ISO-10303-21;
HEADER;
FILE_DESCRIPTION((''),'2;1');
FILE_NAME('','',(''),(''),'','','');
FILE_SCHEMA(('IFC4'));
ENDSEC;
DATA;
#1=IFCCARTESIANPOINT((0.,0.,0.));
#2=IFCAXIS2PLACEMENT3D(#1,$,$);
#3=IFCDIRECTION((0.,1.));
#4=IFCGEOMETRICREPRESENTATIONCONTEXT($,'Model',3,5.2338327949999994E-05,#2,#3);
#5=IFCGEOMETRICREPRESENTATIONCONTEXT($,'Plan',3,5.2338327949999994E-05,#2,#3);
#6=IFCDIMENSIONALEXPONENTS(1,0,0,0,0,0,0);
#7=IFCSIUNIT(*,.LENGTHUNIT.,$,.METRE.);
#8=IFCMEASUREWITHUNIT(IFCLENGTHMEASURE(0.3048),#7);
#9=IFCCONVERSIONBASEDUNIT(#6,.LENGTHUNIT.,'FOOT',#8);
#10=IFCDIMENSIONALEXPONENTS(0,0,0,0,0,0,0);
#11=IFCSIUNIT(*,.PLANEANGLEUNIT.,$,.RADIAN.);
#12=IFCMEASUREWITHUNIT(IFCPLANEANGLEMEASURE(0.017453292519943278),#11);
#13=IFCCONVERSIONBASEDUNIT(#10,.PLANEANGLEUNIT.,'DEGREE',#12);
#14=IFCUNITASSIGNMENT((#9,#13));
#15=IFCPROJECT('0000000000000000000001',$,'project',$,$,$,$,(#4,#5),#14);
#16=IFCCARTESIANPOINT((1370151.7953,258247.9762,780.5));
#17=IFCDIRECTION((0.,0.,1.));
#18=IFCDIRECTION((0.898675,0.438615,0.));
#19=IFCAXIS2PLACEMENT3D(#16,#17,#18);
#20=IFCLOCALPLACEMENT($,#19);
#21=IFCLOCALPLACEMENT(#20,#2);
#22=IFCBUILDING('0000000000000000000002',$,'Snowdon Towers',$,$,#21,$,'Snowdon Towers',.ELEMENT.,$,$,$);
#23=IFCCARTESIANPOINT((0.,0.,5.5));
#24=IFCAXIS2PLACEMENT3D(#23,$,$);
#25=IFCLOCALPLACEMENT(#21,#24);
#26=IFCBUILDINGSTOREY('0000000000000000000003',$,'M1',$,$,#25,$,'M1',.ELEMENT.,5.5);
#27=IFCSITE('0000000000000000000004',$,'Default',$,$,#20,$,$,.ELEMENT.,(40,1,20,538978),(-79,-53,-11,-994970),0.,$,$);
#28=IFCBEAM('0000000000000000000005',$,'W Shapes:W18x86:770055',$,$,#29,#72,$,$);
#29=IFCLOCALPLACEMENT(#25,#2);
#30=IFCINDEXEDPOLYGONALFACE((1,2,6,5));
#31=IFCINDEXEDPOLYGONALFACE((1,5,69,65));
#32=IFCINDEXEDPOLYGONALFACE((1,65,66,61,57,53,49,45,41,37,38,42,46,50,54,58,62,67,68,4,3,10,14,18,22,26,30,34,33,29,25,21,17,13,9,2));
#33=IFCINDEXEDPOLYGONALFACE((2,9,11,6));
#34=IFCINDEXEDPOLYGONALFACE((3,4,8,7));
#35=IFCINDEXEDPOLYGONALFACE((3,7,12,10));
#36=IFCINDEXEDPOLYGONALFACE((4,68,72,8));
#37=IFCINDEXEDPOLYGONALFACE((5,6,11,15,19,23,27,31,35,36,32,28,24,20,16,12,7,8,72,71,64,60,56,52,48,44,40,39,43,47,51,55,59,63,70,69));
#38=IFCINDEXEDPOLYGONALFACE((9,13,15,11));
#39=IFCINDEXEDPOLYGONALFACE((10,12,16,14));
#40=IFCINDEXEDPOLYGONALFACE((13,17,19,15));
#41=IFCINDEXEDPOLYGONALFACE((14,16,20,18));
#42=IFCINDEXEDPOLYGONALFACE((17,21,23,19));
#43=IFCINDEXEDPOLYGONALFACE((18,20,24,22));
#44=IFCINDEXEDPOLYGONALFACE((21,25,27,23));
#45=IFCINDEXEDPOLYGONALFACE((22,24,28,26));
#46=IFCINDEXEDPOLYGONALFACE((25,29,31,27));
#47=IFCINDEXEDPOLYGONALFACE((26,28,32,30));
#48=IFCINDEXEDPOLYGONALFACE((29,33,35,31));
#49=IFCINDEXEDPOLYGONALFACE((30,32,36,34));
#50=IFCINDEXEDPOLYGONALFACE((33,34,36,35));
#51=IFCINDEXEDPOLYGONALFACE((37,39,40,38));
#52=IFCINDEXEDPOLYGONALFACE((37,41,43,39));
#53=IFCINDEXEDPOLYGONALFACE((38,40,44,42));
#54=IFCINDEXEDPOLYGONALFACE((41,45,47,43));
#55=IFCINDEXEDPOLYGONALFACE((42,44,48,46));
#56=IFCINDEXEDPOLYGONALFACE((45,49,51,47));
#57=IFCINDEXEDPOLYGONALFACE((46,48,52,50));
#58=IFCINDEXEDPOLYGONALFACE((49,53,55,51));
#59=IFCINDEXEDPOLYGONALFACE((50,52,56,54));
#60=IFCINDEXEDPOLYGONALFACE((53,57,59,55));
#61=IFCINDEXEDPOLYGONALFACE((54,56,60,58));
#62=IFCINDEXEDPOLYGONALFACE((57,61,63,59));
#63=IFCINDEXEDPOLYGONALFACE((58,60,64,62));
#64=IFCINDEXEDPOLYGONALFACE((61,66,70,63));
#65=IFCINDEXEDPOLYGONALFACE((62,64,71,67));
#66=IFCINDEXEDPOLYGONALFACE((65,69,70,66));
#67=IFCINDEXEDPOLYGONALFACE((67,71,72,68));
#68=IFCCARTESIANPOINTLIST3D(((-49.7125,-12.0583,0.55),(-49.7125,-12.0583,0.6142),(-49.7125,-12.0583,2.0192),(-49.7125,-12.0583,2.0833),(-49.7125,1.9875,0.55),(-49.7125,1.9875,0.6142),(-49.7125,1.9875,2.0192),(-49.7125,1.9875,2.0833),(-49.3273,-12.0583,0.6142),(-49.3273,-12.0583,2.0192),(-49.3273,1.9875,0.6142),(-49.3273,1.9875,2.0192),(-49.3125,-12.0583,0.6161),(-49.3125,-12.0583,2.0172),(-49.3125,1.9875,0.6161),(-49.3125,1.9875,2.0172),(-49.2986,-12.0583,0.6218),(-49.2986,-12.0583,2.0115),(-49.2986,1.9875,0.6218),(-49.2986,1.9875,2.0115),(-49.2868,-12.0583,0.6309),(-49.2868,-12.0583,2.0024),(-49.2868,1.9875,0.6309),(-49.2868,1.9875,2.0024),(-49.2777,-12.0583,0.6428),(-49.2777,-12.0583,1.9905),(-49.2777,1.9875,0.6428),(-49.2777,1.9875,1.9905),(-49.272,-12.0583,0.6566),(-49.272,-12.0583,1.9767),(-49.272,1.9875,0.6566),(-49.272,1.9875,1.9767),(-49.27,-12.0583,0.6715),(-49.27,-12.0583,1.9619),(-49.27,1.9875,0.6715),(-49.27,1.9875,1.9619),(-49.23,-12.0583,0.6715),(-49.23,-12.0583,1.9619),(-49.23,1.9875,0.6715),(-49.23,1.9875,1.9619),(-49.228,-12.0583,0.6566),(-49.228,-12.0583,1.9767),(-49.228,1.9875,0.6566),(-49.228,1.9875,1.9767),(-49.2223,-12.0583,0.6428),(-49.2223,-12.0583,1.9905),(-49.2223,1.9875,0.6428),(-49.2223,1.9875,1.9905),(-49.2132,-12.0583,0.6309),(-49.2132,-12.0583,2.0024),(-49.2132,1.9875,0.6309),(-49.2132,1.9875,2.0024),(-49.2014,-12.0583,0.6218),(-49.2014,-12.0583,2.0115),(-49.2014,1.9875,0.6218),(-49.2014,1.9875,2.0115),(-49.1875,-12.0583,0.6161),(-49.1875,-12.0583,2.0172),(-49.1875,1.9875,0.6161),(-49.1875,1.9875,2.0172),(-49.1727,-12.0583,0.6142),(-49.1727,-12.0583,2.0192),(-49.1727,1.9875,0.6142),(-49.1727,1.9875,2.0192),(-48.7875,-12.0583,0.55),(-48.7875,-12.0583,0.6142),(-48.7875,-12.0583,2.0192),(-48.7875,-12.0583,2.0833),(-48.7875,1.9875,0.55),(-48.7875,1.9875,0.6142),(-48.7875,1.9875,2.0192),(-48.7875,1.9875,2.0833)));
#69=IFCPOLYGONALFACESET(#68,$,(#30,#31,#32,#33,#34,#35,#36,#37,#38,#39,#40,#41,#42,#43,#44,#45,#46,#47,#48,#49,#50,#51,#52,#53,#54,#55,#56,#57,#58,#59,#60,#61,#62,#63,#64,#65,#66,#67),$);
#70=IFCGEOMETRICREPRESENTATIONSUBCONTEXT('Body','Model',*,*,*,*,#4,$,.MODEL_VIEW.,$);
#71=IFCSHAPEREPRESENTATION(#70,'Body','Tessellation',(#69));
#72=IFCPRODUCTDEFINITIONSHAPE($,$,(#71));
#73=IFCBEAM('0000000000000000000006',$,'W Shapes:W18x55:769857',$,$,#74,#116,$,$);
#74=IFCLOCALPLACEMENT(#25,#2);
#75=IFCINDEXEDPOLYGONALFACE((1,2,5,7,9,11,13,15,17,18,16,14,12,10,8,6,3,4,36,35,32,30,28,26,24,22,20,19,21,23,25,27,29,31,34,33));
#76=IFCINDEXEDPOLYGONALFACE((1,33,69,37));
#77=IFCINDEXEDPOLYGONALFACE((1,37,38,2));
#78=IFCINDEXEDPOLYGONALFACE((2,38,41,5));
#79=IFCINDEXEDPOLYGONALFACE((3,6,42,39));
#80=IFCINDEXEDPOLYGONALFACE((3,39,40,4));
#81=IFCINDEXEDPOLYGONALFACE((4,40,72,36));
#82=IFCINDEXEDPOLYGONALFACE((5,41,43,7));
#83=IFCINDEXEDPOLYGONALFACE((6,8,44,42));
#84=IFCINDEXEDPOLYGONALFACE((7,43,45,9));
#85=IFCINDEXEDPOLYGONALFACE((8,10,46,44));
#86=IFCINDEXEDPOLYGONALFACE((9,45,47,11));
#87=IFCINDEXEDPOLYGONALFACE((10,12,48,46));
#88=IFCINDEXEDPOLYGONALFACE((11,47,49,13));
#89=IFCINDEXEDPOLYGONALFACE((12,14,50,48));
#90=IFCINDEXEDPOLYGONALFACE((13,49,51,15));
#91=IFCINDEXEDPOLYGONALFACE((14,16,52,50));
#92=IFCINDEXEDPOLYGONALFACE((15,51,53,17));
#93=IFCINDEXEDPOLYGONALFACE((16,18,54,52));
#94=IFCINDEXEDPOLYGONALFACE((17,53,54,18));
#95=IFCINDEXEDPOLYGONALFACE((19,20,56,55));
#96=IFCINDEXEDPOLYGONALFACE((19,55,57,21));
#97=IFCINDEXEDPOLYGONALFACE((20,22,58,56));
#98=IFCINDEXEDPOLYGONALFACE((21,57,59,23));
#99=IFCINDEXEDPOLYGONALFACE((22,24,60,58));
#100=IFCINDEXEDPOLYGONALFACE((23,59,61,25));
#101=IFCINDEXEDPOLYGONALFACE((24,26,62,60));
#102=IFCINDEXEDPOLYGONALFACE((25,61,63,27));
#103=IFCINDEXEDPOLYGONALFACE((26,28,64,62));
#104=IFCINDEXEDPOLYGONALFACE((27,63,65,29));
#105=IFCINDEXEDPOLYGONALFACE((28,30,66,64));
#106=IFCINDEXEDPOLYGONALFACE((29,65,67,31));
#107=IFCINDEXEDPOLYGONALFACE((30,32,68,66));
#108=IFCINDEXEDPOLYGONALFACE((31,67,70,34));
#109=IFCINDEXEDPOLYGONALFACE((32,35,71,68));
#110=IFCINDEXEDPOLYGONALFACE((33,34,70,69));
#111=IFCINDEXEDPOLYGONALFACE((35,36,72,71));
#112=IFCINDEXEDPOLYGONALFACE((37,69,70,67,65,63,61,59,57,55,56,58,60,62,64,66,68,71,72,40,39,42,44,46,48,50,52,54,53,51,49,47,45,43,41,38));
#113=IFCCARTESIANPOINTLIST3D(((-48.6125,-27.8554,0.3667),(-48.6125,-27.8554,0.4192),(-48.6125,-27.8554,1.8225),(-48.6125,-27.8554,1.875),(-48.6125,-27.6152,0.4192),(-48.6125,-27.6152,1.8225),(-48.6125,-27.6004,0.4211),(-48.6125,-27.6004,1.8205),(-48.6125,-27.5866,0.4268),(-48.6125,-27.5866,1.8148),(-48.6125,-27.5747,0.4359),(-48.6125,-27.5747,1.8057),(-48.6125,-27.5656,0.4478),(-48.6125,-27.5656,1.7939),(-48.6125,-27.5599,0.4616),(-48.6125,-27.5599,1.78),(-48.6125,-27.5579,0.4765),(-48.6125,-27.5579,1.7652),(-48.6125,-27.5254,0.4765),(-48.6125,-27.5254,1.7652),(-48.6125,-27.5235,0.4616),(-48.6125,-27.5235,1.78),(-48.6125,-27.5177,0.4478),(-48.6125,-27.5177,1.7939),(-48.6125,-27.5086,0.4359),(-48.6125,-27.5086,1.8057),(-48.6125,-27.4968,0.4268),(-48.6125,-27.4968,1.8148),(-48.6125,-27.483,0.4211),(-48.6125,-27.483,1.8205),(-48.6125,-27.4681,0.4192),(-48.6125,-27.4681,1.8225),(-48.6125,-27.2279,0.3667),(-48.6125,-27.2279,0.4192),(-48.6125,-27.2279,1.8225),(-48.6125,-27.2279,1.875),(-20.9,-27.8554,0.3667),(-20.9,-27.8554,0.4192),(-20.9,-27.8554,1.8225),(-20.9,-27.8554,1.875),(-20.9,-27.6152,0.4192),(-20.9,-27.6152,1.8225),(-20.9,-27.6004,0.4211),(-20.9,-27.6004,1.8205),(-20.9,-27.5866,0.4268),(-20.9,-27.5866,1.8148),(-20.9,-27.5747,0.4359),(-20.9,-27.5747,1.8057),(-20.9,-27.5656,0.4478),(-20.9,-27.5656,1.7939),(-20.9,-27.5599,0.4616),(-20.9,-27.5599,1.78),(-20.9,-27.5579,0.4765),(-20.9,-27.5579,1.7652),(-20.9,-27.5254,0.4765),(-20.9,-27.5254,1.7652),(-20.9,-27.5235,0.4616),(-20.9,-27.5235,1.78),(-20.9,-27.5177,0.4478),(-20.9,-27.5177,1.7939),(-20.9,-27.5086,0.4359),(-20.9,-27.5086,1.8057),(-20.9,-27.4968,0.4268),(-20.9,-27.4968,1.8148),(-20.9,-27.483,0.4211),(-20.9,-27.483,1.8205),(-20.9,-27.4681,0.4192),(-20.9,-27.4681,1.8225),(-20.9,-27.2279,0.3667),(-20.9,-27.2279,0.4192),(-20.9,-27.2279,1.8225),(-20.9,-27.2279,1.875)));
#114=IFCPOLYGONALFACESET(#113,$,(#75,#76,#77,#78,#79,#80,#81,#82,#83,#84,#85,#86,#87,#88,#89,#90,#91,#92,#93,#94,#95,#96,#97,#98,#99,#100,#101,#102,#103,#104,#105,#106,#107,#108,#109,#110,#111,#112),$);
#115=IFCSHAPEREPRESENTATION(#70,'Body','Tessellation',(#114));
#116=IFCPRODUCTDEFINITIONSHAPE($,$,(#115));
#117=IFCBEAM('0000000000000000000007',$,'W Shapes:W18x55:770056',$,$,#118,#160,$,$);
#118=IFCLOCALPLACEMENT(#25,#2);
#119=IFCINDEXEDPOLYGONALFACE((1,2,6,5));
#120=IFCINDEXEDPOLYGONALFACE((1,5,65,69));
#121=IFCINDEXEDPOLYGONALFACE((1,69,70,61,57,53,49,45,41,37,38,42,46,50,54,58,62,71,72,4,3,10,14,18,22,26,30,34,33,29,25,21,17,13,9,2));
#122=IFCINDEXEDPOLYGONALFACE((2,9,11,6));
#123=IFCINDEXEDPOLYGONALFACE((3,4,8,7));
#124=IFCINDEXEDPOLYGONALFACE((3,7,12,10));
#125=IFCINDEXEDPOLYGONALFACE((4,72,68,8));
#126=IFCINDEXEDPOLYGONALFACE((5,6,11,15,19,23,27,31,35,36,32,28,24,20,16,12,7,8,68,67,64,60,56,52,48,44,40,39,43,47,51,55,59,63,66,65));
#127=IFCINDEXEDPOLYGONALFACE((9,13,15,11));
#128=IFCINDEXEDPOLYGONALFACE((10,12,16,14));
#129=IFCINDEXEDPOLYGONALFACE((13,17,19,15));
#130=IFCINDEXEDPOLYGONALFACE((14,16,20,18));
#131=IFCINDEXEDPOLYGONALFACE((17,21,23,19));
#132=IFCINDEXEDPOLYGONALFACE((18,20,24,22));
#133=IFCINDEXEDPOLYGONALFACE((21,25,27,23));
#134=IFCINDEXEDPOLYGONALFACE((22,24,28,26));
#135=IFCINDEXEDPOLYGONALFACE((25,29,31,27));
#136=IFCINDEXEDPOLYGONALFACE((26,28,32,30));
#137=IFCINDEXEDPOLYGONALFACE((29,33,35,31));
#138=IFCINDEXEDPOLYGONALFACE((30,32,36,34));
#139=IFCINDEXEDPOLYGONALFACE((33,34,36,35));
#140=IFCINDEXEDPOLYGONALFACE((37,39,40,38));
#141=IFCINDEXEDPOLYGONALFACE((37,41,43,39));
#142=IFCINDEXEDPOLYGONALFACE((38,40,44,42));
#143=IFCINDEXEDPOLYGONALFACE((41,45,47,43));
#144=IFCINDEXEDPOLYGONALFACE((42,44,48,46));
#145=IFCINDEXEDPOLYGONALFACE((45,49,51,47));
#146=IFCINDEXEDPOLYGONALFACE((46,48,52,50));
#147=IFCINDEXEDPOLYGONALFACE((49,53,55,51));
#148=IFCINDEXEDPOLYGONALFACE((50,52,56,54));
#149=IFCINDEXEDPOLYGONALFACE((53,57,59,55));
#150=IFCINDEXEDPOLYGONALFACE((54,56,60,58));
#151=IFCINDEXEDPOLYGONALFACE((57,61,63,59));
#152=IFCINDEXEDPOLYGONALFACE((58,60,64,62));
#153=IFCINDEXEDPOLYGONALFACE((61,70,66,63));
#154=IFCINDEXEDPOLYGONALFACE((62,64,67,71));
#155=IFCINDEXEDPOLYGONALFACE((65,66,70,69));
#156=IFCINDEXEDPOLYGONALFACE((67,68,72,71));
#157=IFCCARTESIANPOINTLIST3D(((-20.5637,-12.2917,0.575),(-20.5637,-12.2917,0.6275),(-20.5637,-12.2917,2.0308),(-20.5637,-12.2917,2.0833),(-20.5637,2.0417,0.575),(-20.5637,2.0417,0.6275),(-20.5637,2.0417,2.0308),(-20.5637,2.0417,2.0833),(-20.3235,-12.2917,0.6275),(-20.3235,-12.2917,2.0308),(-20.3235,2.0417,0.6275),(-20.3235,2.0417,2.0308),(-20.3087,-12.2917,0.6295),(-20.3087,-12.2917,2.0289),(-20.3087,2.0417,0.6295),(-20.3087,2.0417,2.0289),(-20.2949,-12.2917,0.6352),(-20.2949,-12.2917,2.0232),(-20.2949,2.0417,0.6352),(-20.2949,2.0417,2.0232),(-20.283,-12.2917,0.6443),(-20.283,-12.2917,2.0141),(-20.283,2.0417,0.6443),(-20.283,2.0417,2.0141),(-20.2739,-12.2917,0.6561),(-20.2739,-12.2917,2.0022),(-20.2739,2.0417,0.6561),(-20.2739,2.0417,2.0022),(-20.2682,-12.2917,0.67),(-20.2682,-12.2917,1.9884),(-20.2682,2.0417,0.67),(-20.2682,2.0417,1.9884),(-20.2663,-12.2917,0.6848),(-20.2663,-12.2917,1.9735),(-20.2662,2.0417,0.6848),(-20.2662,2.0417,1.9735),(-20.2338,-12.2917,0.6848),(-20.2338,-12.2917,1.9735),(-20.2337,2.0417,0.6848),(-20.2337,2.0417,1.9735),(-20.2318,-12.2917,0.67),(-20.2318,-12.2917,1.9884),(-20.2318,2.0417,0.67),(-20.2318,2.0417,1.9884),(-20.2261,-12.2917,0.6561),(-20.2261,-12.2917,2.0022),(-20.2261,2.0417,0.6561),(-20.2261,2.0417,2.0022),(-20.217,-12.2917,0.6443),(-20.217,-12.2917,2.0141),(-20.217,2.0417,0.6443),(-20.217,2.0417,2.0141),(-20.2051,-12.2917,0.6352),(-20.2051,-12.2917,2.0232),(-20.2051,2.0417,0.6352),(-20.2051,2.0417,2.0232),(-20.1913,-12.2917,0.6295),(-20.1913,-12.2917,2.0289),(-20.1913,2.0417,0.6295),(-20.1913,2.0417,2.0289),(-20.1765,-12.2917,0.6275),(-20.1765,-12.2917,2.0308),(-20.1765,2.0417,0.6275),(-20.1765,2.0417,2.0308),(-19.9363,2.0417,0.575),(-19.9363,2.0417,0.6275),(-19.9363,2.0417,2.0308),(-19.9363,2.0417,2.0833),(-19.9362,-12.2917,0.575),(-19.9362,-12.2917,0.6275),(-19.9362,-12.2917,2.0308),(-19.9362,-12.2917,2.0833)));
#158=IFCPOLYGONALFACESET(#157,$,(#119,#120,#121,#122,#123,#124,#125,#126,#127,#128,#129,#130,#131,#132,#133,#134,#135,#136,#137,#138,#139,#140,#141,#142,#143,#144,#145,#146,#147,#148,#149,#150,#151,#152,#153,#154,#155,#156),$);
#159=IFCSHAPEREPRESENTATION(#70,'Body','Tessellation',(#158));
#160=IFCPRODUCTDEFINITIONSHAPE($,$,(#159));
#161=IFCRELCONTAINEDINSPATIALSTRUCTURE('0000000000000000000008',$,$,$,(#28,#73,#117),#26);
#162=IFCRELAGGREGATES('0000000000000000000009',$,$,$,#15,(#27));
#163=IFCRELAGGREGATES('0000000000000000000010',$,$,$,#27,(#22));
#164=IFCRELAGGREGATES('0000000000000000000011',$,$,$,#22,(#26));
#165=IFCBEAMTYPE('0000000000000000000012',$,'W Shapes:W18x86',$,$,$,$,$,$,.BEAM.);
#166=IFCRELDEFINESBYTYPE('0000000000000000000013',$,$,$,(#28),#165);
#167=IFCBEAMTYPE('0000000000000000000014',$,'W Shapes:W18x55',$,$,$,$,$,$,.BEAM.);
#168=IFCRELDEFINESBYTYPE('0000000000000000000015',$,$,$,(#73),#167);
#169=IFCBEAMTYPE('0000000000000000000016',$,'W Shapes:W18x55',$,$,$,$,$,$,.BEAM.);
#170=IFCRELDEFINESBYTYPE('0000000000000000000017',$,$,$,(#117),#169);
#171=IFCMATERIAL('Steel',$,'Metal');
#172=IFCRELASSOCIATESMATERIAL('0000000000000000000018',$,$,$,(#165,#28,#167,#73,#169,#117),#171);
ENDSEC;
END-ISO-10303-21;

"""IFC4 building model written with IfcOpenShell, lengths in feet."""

from ifc_helpers import new_model, entity, si_unit, converted_unit, direction, frame, origin, place, context, subcontext, project, spatial, line, arc, indexed_curve, outline, extrude, source, transform, mapped, material, type_object, type_shapes, element, save


model = new_model("IFC4")

# Units and contexts
model_context = context("Model", 3, precision=5.2338327949999994e-05, world=origin(), true_north=direction((0.0, 1.0)))
plan_context = context("Plan", 3, precision=5.2338327949999994e-05, world=origin(), true_north=direction((0.0, 1.0)))
body_context = subcontext(model_context, "Body", "Model", "MODEL_VIEW")
ifc_project = project(units=[converted_unit("LENGTHUNIT", "FOOT", entity("IfcLengthMeasure", 0.3048), si_unit("LENGTHUNIT", "METRE"), dimensions=[1, 0, 0, 0, 0, 0, 0]), converted_unit("PLANEANGLEUNIT", "DEGREE", entity("IfcPlaneAngleMeasure", 0.017453292519943278), si_unit("PLANEANGLEUNIT", "RADIAN"), dimensions=[0, 0, 0, 0, 0, 0, 0])], contexts=[model_context, plan_context])

# Site, building, storey
site_placement = place(None, frame((1370151.7953, 258247.9762, 780.5), z_axis=(0.0, 0.0, 1.0), x_axis=(0.898675, 0.438615, 0.0)))
site = spatial("IfcSite", under=ifc_project, at=site_placement, Name="Default", CompositionType="ELEMENT", RefLatitude=(40, 1, 20, 538978), RefLongitude=(-79, -53, -11, -994970), RefElevation=0.0)
building_placement = place(site_placement, origin())
building = spatial("IfcBuilding", under=site, at=building_placement, Name="Snowdon Towers", LongName="Snowdon Towers", CompositionType="ELEMENT")
storey_placement = place(building_placement, frame((0.0, 0.0, 5.5)))
storey = spatial("IfcBuildingStorey", under=building, at=storey_placement, Name="M1", LongName="M1", CompositionType="ELEMENT", Elevation=5.5)

# Beams
ifc_material_1 = material(Name="Steel", Category="Metal")
beam_type_1 = type_object("IfcBeamType", Name="W Shapes:W18x86", PredefinedType="BEAM", material=ifc_material_1)
shared_shape_1 = source(origin(), body_context, "Body", "SweptSolid", [
    extrude(outline(indexed_curve([(-0.7667, -0.4625), (-0.7025, -0.4625), (-0.7025, -0.0773), (-0.6857, -0.0368), (-0.6452, -0.02), (0.6452, -0.02), (0.6857, -0.0368), (0.7025, -0.0773), (0.7025, -0.4625), (0.7667, -0.4625), (0.7667, 0.4625), (0.7025, 0.4625), (0.7025, 0.0773), (0.6857, 0.0368), (0.6452, 0.02), (-0.6452, 0.02), (-0.6857, 0.0368), (-0.7025, 0.0773), (-0.7025, 0.4625), (-0.7667, 0.4625)], segments=[line(1, 2, 3), arc(3, 4, 5), line(5, 6), arc(6, 7, 8), line(8, 9, 10, 11, 12, 13), arc(13, 14, 15), line(15, 16), arc(16, 17, 18), line(18, 19, 20, 1)], self_intersect=False)), frame((-7.0917, 0.0, 0.0), z_axis=(1.0, 0.0, 0.0), x_axis=(0.0, 0.0, -1.0)), (0.0, 0.0, 1.0), 14.0458),
])
type_shapes(beam_type_1, [shared_shape_1])
beam_1_placement = place(storey_placement, frame((-49.25, -5.1042, 1.3167), z_axis=(0.0, 0.0, 1.0), x_axis=(0.0, -1.0, 0.0)))
element("IfcBeam", 1, at=beam_1_placement, inside=storey, type_object=beam_type_1, material=ifc_material_1, Name="W Shapes:W18x86:770055", context=body_context, shape_type="MappedRepresentation", body=[
    mapped(shared_shape_1, transform((0.0, 0.0, 0.0), scale=1.0)),
])
beam_type_2 = type_object("IfcBeamType", Name="W Shapes:W18x55", PredefinedType="BEAM", material=ifc_material_1)
shared_shape_2 = source(origin(), body_context, "Body", "SweptSolid", [
    extrude(outline(indexed_curve([(-0.7542, -0.3138), (-0.7017, -0.3138), (-0.7017, -0.0735), (-0.6849, -0.033), (-0.6444, -0.0162), (0.6444, -0.0162), (0.6849, -0.033), (0.7017, -0.0735), (0.7017, -0.3138), (0.7542, -0.3138), (0.7542, 0.3138), (0.7017, 0.3138), (0.7017, 0.0735), (0.6849, 0.033), (0.6444, 0.0163), (-0.6444, 0.0163), (-0.6849, 0.033), (-0.7017, 0.0735), (-0.7017, 0.3137), (-0.7542, 0.3137)], segments=[line(1, 2, 3), arc(3, 4, 5), line(5, 6), arc(6, 7, 8), line(8, 9, 10, 11, 12, 13), arc(13, 14, 15), line(15, 16), arc(16, 17, 18), line(18, 19, 20, 1)], self_intersect=False)), frame((-13.8625, 0.0, 0.0), z_axis=(1.0, 0.0, 0.0), x_axis=(0.0, 0.0, -1.0)), (0.0, 0.0, 1.0), 27.7125),
])
type_shapes(beam_type_2, [shared_shape_2])
beam_2_placement = place(storey_placement, frame((-34.75, -27.5417, 1.1208)))
element("IfcBeam", 2, at=beam_2_placement, inside=storey, type_object=beam_type_2, material=ifc_material_1, Name="W Shapes:W18x55:769857", context=body_context, shape_type="MappedRepresentation", body=[
    mapped(shared_shape_2, transform((0.0, 0.0, 0.0), scale=1.0)),
])
beam_type_3 = type_object("IfcBeamType", Name="W Shapes:W18x55", PredefinedType="BEAM", material=ifc_material_1)
shared_shape_3 = source(origin(), body_context, "Body", "SweptSolid", [
    extrude(outline(indexed_curve([(-0.7542, -0.3138), (-0.7017, -0.3138), (-0.7017, -0.0735), (-0.6849, -0.033), (-0.6444, -0.0162), (0.6444, -0.0162), (0.6849, -0.033), (0.7017, -0.0735), (0.7017, -0.3138), (0.7542, -0.3138), (0.7542, 0.3138), (0.7017, 0.3138), (0.7017, 0.0735), (0.6849, 0.033), (0.6444, 0.0163), (-0.6444, 0.0163), (-0.6849, 0.033), (-0.7017, 0.0735), (-0.7017, 0.3137), (-0.7542, 0.3137)], segments=[line(1, 2, 3), arc(3, 4, 5), line(5, 6), arc(6, 7, 8), line(8, 9, 10, 11, 12, 13), arc(13, 14, 15), line(15, 16), arc(16, 17, 18), line(18, 19, 20, 1)], self_intersect=False)), frame((-7.1458, 0.0, 0.0), z_axis=(1.0, 0.0, 0.0), x_axis=(0.0, 0.0, -1.0)), (0.0, 0.0, 1.0), 14.3333),
])
type_shapes(beam_type_3, [shared_shape_3])
beam_3_placement = place(storey_placement, frame((-20.25, -5.1042, 1.3292), z_axis=(0.0, 0.0, 1.0), x_axis=(0.0, -1.0, 0.0)))
element("IfcBeam", 3, at=beam_3_placement, inside=storey, type_object=beam_type_3, material=ifc_material_1, Name="W Shapes:W18x55:770056", context=body_context, shape_type="MappedRepresentation", body=[
    mapped(shared_shape_3, transform((0.0, 0.0, 0.0), scale=1.0)),
])

save(model, "model.ifc")
